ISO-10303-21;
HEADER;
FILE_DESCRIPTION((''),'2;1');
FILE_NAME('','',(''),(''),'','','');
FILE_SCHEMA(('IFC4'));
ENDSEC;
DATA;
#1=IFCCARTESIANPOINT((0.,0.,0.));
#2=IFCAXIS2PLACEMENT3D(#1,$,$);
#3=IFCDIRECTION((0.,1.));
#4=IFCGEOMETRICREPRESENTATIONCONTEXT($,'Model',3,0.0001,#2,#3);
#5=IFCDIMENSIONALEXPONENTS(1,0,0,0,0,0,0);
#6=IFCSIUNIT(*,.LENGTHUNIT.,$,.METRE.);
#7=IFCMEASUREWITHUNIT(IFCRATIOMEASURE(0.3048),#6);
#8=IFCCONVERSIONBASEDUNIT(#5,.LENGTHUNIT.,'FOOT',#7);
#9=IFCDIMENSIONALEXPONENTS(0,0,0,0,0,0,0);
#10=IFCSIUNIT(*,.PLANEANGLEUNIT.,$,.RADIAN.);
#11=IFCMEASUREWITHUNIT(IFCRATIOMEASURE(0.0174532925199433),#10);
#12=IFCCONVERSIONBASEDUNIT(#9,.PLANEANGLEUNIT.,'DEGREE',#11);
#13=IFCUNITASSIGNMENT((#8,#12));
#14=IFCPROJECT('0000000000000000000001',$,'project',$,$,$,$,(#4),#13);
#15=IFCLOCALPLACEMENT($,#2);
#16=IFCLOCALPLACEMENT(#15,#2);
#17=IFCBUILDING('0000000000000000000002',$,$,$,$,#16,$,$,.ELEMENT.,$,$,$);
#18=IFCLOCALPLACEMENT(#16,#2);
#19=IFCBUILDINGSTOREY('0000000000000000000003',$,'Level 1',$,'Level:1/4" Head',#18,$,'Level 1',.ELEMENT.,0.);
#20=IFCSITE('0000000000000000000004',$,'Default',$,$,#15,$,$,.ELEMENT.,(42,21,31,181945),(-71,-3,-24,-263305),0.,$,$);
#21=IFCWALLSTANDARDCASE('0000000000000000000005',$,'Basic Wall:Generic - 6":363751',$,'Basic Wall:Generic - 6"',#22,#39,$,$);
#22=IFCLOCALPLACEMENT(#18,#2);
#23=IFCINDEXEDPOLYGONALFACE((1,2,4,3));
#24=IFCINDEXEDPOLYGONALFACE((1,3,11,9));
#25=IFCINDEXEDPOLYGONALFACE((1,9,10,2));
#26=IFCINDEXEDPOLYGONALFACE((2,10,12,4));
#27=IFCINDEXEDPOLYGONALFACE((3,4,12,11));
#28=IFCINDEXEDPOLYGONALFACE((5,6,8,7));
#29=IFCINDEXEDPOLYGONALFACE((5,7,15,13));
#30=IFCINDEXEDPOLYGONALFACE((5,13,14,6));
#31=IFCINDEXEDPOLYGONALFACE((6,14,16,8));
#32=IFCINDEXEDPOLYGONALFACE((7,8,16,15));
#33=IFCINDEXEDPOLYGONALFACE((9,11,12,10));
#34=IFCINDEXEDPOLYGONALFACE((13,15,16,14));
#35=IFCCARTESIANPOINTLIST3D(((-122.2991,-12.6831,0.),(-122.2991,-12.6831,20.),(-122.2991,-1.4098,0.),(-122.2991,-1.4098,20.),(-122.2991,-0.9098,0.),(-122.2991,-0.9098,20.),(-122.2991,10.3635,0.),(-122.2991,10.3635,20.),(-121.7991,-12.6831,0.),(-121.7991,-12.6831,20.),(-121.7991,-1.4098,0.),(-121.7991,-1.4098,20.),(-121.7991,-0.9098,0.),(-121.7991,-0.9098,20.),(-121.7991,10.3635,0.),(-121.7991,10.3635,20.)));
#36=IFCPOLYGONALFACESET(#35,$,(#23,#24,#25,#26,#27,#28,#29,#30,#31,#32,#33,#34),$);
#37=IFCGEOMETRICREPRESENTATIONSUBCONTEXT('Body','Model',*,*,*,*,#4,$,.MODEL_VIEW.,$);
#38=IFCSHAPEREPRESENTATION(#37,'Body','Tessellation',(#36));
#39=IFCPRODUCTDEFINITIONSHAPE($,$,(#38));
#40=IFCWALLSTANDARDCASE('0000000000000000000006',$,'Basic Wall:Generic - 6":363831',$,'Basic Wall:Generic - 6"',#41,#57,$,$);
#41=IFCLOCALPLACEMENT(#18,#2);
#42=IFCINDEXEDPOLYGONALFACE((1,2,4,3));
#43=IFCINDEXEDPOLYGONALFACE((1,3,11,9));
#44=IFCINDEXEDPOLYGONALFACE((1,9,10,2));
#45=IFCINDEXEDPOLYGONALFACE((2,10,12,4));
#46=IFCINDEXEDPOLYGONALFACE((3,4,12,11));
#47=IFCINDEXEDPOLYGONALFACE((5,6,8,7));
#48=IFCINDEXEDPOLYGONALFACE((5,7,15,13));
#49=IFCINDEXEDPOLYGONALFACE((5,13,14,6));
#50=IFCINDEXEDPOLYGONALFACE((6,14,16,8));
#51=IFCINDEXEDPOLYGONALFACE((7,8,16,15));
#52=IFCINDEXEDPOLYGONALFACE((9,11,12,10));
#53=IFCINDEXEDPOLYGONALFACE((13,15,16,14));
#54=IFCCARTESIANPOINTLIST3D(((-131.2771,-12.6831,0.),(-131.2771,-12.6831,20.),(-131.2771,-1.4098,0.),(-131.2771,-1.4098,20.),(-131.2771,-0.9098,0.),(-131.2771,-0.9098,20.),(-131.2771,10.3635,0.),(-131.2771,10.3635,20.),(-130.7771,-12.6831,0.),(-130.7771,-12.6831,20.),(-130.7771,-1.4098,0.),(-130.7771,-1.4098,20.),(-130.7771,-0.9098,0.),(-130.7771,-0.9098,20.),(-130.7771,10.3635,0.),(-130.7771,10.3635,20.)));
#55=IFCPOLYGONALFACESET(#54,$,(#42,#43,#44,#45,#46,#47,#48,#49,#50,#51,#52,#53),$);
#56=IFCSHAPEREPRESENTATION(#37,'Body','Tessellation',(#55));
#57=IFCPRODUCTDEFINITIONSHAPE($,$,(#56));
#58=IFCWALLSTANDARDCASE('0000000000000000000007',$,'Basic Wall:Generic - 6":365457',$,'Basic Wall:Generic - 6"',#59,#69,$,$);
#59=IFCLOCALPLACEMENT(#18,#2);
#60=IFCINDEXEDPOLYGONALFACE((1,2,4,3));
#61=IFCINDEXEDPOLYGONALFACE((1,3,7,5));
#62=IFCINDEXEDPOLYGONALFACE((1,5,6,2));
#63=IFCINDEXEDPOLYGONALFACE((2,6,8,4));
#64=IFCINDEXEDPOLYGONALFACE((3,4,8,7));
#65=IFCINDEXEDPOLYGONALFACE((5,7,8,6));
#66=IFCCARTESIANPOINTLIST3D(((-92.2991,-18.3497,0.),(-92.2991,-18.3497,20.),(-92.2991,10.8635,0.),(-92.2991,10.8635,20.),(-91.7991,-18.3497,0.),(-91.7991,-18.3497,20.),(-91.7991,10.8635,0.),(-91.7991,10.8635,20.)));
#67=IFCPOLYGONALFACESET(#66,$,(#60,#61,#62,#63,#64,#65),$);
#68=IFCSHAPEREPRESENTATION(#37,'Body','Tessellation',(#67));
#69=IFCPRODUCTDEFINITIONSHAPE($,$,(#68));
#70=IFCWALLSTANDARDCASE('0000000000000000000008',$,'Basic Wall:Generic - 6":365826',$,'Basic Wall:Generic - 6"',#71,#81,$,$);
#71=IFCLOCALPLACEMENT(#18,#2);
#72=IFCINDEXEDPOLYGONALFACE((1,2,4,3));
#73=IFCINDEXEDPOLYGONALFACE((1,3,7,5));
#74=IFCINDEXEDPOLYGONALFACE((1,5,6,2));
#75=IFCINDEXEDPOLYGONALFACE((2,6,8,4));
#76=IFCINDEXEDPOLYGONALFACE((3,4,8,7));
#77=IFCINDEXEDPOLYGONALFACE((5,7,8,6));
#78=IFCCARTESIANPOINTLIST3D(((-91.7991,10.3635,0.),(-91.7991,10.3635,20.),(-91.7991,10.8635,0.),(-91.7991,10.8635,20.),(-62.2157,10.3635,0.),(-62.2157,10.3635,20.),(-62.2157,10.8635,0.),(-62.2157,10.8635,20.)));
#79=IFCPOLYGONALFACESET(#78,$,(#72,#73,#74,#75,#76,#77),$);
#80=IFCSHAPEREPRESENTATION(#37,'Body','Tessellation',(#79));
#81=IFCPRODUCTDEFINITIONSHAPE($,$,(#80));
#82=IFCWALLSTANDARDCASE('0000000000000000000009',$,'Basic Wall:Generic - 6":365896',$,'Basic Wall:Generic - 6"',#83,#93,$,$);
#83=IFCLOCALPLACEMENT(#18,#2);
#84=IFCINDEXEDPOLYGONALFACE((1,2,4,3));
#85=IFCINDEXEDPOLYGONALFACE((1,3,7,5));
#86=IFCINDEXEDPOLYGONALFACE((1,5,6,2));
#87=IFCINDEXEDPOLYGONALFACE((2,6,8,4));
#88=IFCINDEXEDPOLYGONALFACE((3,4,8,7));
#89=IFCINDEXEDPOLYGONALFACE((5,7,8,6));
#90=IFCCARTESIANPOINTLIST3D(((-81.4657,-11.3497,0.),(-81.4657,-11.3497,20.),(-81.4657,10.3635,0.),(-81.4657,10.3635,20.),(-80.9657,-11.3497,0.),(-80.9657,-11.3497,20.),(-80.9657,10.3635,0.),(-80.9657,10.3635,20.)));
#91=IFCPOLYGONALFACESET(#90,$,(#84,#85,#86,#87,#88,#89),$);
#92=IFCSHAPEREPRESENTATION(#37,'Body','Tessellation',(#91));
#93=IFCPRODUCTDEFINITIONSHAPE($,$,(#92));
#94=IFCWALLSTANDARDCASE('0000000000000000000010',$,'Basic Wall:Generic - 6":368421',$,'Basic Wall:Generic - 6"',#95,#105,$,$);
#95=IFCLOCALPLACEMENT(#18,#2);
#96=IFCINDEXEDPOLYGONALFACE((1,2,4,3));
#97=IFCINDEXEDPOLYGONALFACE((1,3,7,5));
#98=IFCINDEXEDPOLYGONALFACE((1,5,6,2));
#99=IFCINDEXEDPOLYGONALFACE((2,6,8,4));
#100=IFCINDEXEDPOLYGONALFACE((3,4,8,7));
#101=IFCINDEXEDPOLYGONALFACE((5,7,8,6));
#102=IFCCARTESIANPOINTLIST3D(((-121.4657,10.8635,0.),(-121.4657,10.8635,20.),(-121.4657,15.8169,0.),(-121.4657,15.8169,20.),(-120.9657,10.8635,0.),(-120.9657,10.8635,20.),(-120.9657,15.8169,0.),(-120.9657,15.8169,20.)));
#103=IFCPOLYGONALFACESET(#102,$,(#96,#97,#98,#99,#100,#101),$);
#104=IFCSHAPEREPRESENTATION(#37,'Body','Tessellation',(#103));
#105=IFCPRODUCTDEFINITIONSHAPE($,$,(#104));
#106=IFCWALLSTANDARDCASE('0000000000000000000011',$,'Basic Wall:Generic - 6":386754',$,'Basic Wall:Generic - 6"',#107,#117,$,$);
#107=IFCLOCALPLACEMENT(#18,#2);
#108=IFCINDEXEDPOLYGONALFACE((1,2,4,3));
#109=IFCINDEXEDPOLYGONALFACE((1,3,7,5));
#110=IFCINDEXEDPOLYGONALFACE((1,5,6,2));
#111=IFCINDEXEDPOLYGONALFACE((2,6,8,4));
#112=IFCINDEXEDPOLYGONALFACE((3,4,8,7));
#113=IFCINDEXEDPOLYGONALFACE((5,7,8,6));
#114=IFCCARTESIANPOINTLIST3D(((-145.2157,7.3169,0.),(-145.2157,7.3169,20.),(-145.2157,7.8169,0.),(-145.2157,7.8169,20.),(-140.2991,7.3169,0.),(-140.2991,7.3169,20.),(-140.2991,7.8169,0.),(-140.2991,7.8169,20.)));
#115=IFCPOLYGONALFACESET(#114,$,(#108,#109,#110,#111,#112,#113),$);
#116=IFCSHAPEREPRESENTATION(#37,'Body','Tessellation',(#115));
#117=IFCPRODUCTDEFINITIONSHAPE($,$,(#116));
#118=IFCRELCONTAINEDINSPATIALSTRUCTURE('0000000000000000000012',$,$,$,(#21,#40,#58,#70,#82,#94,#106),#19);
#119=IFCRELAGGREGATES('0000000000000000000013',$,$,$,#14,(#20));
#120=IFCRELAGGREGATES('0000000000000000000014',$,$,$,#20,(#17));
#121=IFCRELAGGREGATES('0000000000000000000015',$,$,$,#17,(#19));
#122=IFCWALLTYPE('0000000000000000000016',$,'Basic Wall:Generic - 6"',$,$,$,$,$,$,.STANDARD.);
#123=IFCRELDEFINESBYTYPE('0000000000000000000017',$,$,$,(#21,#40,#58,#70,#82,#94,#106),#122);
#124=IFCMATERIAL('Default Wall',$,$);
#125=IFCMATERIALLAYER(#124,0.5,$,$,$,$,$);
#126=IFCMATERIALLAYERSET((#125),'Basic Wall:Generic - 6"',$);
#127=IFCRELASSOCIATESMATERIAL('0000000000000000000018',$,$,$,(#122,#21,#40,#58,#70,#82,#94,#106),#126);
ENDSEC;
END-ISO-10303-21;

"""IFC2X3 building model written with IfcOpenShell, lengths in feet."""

from ifc_helpers import new_model, entity, si_unit, converted_unit, direction, frame, frame_2d, origin, origin_2d_with_axis, place, context, subcontext, project, spatial, rectangle, extrude, material, layer, layer_set, layer_usage, type_object, element, save


model = new_model("IFC2X3")

# Units and contexts
model_context = context("Model", 3, precision=0.0001, world=origin(), true_north=direction((0.0, 1.0)))
body_context = subcontext(model_context, "Body", "Model", "MODEL_VIEW")
ifc_project = project(units=[converted_unit("LENGTHUNIT", "FOOT", entity("IfcRatioMeasure", 0.3048), si_unit("LENGTHUNIT", "METRE"), dimensions=[1, 0, 0, 0, 0, 0, 0]), converted_unit("PLANEANGLEUNIT", "DEGREE", entity("IfcRatioMeasure", 0.0174532925199433), si_unit("PLANEANGLEUNIT", "RADIAN"), dimensions=[0, 0, 0, 0, 0, 0, 0])], contexts=[model_context])

# Site, building, storey
site_placement = place(None, origin())
site = spatial("IfcSite", under=ifc_project, at=site_placement, Name="Default", CompositionType="ELEMENT", RefLatitude=(42, 21, 31, 181945), RefLongitude=(-71, -3, -24, -263305), RefElevation=0.0)
building_placement = place(site_placement, origin())
building = spatial("IfcBuilding", under=site, at=building_placement, CompositionType="ELEMENT")
storey_placement = place(building_placement, origin())
storey = spatial("IfcBuildingStorey", under=building, at=storey_placement, Name="Level 1", ObjectType="Level:1/4\" Head", LongName="Level 1", CompositionType="ELEMENT", Elevation=0.0)

# Shared definitions
ifc_material = material(Name="Default Wall")
ifc_layer_1 = layer(ifc_material, 0.5)
ifc_layer_set_1 = layer_set([ifc_layer_1], Name="Basic Wall:Generic - 6\"")
wall_type_1 = type_object("IfcWallType", Name="Basic Wall:Generic - 6\"", PredefinedType="STANDARD", material=ifc_layer_set_1)

# Walls, openings
ifc_layer_usage_1 = layer_usage(ifc_layer_set_1, "AXIS2", "NEGATIVE", 0.25)
wall_1_placement = place(storey_placement, frame((-122.0491, 10.3635, 0.0), z_axis=(0.0, 0.0, 1.0), x_axis=(0.0, -1.0, 0.0)))
wall_1 = element("IfcWallStandardCase", 1, at=wall_1_placement, inside=storey, type_object=wall_type_1, material=ifc_layer_usage_1, Name="Basic Wall:Generic - 6\":363751", ObjectType="Basic Wall:Generic - 6\"", context=body_context, shape_type="SweptSolid", body=[
    extrude(rectangle(XDim=23.0466, YDim=0.5, at=frame_2d((11.5233, 0.0), x_axis=(-1.0, 0.0))), origin(), (0.0, 0.0, 1.0), 20.0),
])
opening_1_placement = place(storey_placement, frame((-122.0491, 10.3635, 0.0), z_axis=(0.0, 0.0, 1.0), x_axis=(0.0, -1.0, 0.0)))
element("IfcOpeningElement", 2, at=opening_1_placement, cuts=wall_1, ObjectType="Opening", context=body_context, shape_type="SweptSolid", body=[
    extrude(rectangle(XDim=20.0, YDim=0.5, at=origin_2d_with_axis()), frame((11.7733, 0.0, 10.0), z_axis=(-1.0, 0.0, 0.0), x_axis=(0.0, 0.0, 1.0)), (0.0, 0.0, 1.0), 0.5),
])
ifc_layer_usage_2 = layer_usage(ifc_layer_set_1, "AXIS2", "NEGATIVE", 0.25)
wall_2_placement = place(storey_placement, frame((-131.0271, 10.3635, 0.0), z_axis=(0.0, 0.0, 1.0), x_axis=(0.0, -1.0, 0.0)))
wall_2 = element("IfcWallStandardCase", 3, at=wall_2_placement, inside=storey, type_object=wall_type_1, material=ifc_layer_usage_2, Name="Basic Wall:Generic - 6\":363831", ObjectType="Basic Wall:Generic - 6\"", context=body_context, shape_type="SweptSolid", body=[
    extrude(rectangle(XDim=23.0466, YDim=0.5, at=frame_2d((11.5233, 0.0), x_axis=(-1.0, 0.0))), origin(), (0.0, 0.0, 1.0), 20.0),
])
opening_2_placement = place(storey_placement, frame((-131.0271, 10.3635, 0.0), z_axis=(0.0, 0.0, 1.0), x_axis=(0.0, -1.0, 0.0)))
element("IfcOpeningElement", 4, at=opening_2_placement, cuts=wall_2, ObjectType="Opening", context=body_context, shape_type="SweptSolid", body=[
    extrude(rectangle(XDim=20.0, YDim=0.5, at=origin_2d_with_axis()), frame((11.7733, 0.0, 10.0), z_axis=(-1.0, 0.0, 0.0), x_axis=(0.0, 0.0, 1.0)), (0.0, 0.0, 1.0), 0.5),
])

# Walls
ifc_layer_usage_3 = layer_usage(ifc_layer_set_1, "AXIS2", "NEGATIVE", 0.25)
wall_3_placement = place(storey_placement, frame((-92.0491, 10.8635, 0.0), z_axis=(0.0, 0.0, 1.0), x_axis=(0.0, -1.0, 0.0)))
element("IfcWallStandardCase", 5, at=wall_3_placement, inside=storey, type_object=wall_type_1, material=ifc_layer_usage_3, Name="Basic Wall:Generic - 6\":365457", ObjectType="Basic Wall:Generic - 6\"", context=body_context, shape_type="SweptSolid", body=[
    extrude(rectangle(XDim=29.2133, YDim=0.5, at=frame_2d((14.6066, 0.0), x_axis=(-1.0, 0.0))), origin(), (0.0, 0.0, 1.0), 20.0),
])
ifc_layer_usage_4 = layer_usage(ifc_layer_set_1, "AXIS2", "NEGATIVE", 0.25)
wall_4_placement = place(storey_placement, frame((-91.7991, 10.6135, 0.0)))
element("IfcWallStandardCase", 6, at=wall_4_placement, inside=storey, type_object=wall_type_1, material=ifc_layer_usage_4, Name="Basic Wall:Generic - 6\":365826", ObjectType="Basic Wall:Generic - 6\"", context=body_context, shape_type="SweptSolid", body=[
    extrude(rectangle(XDim=29.5833, YDim=0.5, at=frame_2d((14.7917, 0.0), x_axis=(-1.0, 0.0))), origin(), (0.0, 0.0, 1.0), 20.0),
])
ifc_layer_usage_5 = layer_usage(ifc_layer_set_1, "AXIS2", "NEGATIVE", 0.25)
wall_5_placement = place(storey_placement, frame((-81.2157, 10.3635, 0.0), z_axis=(0.0, 0.0, 1.0), x_axis=(0.0, -1.0, 0.0)))
element("IfcWallStandardCase", 7, at=wall_5_placement, inside=storey, type_object=wall_type_1, material=ifc_layer_usage_5, Name="Basic Wall:Generic - 6\":365896", ObjectType="Basic Wall:Generic - 6\"", context=body_context, shape_type="SweptSolid", body=[
    extrude(rectangle(XDim=21.7133, YDim=0.5, at=frame_2d((10.8566, 0.0), x_axis=(-1.0, 0.0))), origin(), (0.0, 0.0, 1.0), 20.0),
])
ifc_layer_usage_6 = layer_usage(ifc_layer_set_1, "AXIS2", "NEGATIVE", 0.25)
wall_6_placement = place(storey_placement, frame((-121.2157, 15.8169, 0.0), z_axis=(0.0, 0.0, 1.0), x_axis=(0.0, -1.0, 0.0)))
element("IfcWallStandardCase", 8, at=wall_6_placement, inside=storey, type_object=wall_type_1, material=ifc_layer_usage_6, Name="Basic Wall:Generic - 6\":368421", ObjectType="Basic Wall:Generic - 6\"", context=body_context, shape_type="SweptSolid", body=[
    extrude(rectangle(XDim=4.9534, YDim=0.5, at=frame_2d((2.4767, 0.0), x_axis=(-1.0, 0.0))), origin(), (0.0, 0.0, 1.0), 20.0),
])
ifc_layer_usage_7 = layer_usage(ifc_layer_set_1, "AXIS2", "NEGATIVE", 0.25)
wall_7_placement = place(storey_placement, frame((-140.2991, 7.5669, 0.0), z_axis=(0.0, 0.0, 1.0), x_axis=(-1.0, 0.0, 0.0)))
element("IfcWallStandardCase", 9, at=wall_7_placement, inside=storey, type_object=wall_type_1, material=ifc_layer_usage_7, Name="Basic Wall:Generic - 6\":386754", ObjectType="Basic Wall:Generic - 6\"", context=body_context, shape_type="SweptSolid", body=[
    extrude(rectangle(XDim=4.9167, YDim=0.5, at=frame_2d((2.4583, 0.0), x_axis=(-1.0, 0.0))), origin(), (0.0, 0.0, 1.0), 20.0),
])

save(model, "model.ifc")
